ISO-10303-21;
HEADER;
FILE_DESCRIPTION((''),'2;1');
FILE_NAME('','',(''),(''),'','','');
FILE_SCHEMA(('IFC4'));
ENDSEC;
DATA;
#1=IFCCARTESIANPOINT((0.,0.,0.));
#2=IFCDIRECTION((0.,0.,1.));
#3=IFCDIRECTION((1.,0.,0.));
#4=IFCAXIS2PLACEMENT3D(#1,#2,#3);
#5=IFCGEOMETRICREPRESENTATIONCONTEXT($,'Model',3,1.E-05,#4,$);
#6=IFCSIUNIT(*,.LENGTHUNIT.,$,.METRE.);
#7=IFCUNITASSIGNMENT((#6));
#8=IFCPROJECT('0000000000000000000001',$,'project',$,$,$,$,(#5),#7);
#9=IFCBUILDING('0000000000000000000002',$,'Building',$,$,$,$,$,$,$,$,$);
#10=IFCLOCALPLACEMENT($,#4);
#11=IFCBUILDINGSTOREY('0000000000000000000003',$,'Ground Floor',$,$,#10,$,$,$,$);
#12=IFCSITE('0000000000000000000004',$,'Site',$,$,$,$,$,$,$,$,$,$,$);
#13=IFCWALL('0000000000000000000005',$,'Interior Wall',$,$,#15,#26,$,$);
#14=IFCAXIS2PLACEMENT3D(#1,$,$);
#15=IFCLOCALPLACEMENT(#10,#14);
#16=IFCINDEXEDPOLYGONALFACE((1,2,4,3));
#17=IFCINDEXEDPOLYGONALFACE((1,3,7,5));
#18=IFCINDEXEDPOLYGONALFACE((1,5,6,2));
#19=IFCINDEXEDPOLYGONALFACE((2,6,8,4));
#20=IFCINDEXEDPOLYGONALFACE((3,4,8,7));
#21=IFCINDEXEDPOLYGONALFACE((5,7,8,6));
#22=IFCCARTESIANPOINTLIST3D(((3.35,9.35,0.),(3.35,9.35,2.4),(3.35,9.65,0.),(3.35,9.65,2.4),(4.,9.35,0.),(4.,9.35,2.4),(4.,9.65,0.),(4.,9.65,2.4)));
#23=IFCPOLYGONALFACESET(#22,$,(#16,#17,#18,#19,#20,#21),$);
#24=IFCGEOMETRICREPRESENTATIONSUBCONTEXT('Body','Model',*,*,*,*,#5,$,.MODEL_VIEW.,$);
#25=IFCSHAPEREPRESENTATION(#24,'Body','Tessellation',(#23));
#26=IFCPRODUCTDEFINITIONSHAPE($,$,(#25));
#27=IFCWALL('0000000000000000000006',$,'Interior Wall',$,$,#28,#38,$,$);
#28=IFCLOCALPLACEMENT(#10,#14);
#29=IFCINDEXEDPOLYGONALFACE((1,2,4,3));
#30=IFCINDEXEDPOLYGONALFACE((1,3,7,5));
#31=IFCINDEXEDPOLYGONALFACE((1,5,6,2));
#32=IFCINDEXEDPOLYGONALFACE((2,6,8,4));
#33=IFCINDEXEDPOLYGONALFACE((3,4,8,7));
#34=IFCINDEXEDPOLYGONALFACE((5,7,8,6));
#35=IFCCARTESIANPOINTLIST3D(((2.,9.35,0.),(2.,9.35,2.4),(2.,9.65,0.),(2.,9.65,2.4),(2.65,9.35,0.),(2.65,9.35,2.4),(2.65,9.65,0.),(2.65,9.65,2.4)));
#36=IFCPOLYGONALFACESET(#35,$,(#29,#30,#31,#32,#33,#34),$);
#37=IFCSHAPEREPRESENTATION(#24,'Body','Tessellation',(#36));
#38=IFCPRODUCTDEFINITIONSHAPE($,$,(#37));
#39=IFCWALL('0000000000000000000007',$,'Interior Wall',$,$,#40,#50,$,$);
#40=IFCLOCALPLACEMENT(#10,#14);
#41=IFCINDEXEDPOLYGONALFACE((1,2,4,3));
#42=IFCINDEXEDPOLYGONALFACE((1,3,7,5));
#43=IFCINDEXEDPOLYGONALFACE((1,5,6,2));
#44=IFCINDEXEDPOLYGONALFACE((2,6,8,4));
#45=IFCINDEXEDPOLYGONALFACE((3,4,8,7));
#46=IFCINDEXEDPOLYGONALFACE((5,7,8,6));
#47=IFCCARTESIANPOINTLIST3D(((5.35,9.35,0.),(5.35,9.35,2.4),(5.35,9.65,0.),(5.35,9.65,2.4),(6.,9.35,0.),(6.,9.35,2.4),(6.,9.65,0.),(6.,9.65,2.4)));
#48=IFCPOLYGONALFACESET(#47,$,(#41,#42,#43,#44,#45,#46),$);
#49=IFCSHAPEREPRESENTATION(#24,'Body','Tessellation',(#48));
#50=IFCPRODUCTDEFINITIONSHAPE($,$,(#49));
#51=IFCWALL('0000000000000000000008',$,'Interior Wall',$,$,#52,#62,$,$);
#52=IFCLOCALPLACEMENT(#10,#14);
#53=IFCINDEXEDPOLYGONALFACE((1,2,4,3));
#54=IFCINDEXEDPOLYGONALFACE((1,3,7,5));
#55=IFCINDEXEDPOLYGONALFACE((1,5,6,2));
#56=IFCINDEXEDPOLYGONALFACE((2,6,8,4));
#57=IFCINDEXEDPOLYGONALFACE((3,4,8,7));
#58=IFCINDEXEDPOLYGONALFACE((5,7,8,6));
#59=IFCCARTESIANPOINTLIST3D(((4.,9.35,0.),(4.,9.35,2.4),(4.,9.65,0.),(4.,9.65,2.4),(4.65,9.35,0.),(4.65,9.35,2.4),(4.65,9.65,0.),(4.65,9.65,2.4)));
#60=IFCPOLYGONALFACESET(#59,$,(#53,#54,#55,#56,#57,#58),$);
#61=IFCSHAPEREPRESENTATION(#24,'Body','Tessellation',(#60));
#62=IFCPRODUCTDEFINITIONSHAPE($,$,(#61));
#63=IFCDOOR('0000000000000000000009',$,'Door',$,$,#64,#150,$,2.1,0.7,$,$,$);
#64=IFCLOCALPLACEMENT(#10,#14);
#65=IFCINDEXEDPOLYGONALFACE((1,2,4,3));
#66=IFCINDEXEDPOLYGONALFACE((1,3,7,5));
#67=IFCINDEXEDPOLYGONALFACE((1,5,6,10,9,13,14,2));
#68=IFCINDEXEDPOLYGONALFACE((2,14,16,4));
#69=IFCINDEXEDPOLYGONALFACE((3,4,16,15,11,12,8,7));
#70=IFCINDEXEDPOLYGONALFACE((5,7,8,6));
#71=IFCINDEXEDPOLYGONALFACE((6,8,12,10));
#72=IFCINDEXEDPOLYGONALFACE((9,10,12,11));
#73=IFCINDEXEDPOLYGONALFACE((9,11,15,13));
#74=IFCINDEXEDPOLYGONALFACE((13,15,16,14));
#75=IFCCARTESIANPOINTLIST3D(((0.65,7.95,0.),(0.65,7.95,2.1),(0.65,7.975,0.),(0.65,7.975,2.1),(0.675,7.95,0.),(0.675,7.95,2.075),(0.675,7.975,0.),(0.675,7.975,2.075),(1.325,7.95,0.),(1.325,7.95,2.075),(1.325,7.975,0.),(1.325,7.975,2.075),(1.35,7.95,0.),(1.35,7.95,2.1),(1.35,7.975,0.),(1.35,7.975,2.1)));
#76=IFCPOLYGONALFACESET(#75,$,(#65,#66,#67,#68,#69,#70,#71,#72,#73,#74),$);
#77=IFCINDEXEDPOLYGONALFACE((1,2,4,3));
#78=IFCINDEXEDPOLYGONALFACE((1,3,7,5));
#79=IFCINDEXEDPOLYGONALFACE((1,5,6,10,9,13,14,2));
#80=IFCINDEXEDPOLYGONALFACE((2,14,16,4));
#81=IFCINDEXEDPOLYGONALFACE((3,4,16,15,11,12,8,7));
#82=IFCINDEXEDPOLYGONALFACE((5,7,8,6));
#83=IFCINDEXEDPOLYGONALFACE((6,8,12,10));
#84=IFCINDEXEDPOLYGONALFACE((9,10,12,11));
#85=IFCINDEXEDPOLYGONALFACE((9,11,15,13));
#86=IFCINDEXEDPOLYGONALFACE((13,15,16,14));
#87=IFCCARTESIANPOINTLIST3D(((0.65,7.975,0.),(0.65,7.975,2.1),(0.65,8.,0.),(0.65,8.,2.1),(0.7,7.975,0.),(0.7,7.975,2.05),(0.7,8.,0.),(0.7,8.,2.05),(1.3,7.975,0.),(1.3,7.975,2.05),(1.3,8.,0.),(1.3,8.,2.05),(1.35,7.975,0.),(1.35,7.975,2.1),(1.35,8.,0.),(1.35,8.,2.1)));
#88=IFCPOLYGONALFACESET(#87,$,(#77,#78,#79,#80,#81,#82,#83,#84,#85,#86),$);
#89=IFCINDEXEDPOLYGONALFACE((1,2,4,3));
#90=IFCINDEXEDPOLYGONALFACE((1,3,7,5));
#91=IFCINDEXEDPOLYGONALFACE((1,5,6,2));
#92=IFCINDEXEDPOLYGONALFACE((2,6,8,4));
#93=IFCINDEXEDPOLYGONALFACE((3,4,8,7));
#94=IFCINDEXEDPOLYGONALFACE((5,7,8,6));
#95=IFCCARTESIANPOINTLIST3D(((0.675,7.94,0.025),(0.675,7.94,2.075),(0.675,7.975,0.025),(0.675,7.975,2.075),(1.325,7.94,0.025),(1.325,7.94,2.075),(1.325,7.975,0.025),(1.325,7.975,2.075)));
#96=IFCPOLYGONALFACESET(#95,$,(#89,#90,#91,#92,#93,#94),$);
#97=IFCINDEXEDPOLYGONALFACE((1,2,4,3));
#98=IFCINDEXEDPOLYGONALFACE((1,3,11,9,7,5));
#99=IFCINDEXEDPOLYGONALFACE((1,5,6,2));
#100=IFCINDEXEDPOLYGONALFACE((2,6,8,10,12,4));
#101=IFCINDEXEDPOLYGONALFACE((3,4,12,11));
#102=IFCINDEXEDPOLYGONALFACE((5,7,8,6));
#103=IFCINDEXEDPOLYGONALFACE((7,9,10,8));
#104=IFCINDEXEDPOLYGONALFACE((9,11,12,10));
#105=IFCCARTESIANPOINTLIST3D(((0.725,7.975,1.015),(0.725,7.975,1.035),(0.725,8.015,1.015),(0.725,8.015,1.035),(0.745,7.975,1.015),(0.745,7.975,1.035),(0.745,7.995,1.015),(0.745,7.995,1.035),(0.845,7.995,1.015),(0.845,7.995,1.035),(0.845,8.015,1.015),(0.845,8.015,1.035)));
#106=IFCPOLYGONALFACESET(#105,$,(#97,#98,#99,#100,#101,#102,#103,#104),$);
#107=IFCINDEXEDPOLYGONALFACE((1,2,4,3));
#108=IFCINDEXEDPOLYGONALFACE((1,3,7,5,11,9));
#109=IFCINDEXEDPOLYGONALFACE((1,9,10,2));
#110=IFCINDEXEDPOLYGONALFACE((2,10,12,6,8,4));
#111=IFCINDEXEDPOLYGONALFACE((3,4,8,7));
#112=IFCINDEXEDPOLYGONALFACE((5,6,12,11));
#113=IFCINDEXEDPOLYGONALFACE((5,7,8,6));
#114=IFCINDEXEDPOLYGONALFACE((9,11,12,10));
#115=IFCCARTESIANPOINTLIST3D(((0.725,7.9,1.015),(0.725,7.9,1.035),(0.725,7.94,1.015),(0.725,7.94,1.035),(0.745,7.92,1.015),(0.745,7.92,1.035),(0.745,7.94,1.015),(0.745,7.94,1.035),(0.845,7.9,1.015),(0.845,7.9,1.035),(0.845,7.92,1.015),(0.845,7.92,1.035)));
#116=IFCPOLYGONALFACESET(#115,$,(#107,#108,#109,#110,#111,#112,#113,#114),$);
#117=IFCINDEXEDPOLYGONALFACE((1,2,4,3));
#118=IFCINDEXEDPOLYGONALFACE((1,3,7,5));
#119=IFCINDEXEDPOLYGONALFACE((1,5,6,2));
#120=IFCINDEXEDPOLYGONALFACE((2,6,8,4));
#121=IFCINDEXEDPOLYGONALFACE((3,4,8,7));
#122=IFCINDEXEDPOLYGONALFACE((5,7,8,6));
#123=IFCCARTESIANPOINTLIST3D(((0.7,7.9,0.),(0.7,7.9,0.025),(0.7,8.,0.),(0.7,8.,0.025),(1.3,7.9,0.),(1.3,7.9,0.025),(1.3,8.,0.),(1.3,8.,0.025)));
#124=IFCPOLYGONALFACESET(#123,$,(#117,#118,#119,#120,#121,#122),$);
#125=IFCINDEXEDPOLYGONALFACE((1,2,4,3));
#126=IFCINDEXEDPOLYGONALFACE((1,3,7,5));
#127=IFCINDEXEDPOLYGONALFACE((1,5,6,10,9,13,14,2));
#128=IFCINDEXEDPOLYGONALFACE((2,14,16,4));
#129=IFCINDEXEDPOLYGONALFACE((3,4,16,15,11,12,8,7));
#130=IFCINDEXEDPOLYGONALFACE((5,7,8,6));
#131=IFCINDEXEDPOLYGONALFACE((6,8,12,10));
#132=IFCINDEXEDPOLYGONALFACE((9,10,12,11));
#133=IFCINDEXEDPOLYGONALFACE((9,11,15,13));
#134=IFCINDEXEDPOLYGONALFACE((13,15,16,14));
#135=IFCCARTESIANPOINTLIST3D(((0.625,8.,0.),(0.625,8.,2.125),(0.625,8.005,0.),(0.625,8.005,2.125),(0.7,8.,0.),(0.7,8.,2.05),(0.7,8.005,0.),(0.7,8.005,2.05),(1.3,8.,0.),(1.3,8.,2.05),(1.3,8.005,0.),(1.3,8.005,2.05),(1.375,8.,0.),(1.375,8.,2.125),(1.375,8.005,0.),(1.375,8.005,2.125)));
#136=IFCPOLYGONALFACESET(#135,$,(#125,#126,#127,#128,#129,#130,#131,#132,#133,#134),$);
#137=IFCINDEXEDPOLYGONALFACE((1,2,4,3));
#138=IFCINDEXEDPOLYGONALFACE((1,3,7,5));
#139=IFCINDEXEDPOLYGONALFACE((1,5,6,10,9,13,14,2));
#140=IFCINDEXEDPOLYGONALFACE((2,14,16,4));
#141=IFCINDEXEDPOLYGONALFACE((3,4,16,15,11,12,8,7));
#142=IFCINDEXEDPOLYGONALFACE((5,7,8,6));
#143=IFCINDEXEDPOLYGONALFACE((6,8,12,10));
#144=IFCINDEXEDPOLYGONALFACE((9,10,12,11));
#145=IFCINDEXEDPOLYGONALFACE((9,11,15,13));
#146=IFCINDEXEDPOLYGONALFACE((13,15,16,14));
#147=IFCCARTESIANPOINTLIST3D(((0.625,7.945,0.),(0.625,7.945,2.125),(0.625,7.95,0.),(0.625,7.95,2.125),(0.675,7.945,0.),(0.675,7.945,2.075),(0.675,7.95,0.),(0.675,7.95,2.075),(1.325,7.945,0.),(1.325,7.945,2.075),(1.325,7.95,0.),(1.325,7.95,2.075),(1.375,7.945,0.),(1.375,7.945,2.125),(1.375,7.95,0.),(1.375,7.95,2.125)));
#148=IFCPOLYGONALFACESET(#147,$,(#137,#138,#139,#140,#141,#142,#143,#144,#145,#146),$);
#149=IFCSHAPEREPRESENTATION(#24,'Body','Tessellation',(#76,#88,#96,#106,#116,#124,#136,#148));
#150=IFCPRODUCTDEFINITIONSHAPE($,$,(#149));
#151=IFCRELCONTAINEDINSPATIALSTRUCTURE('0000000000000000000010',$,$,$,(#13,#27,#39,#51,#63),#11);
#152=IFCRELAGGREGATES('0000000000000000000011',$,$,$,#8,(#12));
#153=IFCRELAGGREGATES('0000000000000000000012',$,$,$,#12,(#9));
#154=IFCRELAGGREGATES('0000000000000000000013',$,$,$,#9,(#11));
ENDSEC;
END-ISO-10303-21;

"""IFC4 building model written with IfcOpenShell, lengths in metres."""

from ifc_helpers import new_model, si_unit, frame, origin_with_axes, place, context, subcontext, project, spatial, line, indexed_curve, outline, extrude, element, save


model = new_model("IFC4")

# Units and contexts
model_context = context("Model", 3, precision=1e-05, world=origin_with_axes())
body_context = subcontext(model_context, "Body", "Model", "MODEL_VIEW")
ifc_project = project(units=[si_unit("LENGTHUNIT", "METRE")], contexts=[model_context])

# Site, building, storey
site = spatial("IfcSite", under=ifc_project, Name="Site")
building = spatial("IfcBuilding", under=site, Name="Building")
storey_placement = place(None, origin_with_axes())
storey = spatial("IfcBuildingStorey", under=building, at=storey_placement, Name="Ground Floor")

# Walls
for number, where, z_axis, x_axis, name in (
    (1, (4.0, 9.5, 0.0), (0.0, 0.0, 1.0), (-1.0, 0.0, 0.0), "Interior Wall"),
    (2, (2.65, 9.5, 0.0), (0.0, 0.0, 1.0), (-1.0, 0.0, 0.0), "Interior Wall"),
):
    element("IfcWall", number, at=place(storey_placement, frame(where, z_axis=z_axis, x_axis=x_axis)), inside=storey, Name=name, context=body_context, shape_type="SweptSolid", body=[
        extrude(outline(indexed_curve([(0.0, 0.0), (0.0, 0.3), (0.65, 0.3), (0.65, 0.0), (0.0, 0.0)], self_intersect=False)), frame((0.0, -0.15, 0.0), z_axis=(0.0, 0.0, 1.0), x_axis=(1.0, 0.0, 0.0)), (0.0, 0.0, 1.0), 2.4),
    ])
for number, where, z_axis, x_axis, name in (
    (3, (6.0, 9.5, 0.0), (0.0, 0.0, 1.0), (-1.0, 0.0, 0.0), "Interior Wall"),
    (4, (4.65, 9.5, 0.0), (0.0, 0.0, 1.0), (-1.0, 0.0, 0.0), "Interior Wall"),
):
    element("IfcWall", number, at=place(storey_placement, frame(where, z_axis=z_axis, x_axis=x_axis)), inside=storey, Name=name, context=body_context, shape_type="SweptSolid", body=[
        extrude(outline(indexed_curve([(0.0, 0.0), (0.0, 0.3), (0.65, 0.3), (0.65, 0.0), (0.0, 0.0)], self_intersect=False)), frame((0.0, -0.15, 0.0), z_axis=(0.0, 0.0, 1.0), x_axis=(1.0, 0.0, 0.0)), (0.0, 0.0, 1.0), 2.4),
    ])

# Door
door_1_placement = place(storey_placement, frame((1.35, 8.0, 0.0), z_axis=(0.0, 0.0, 1.0), x_axis=(-1.0, 0.0, 0.0)))
element("IfcDoor", 5, at=door_1_placement, inside=storey, Name="Door", OverallHeight=2.1, OverallWidth=0.7, context=body_context, shape_type="SweptSolid", body=[
    extrude(outline(indexed_curve([(0.0, 0.0), (0.0, 2.1), (0.7, 2.1), (0.7, 0.0), (0.675, 0.0), (0.675, 2.075), (0.025, 2.075), (0.025, 0.0)], segments=[line(1, 2, 3, 4, 5, 6, 7, 8, 1)])), frame((0.0, 0.025, 0.0), z_axis=(0.0, -1.0, 0.0), x_axis=(1.0, 0.0, 0.0)), (0.0, 0.0, -1.0), 0.025),
    extrude(outline(indexed_curve([(0.0, 0.0), (0.0, 2.1), (0.7, 2.1), (0.7, 0.0), (0.65, 0.0), (0.65, 2.05), (0.05, 2.05), (0.05, 0.0)], segments=[line(1, 2, 3, 4, 5, 6, 7, 8, 1)])), frame((0.0, 0.0, 0.0), z_axis=(0.0, -1.0, 0.0), x_axis=(1.0, 0.0, 0.0)), (0.0, 0.0, -1.0), 0.025),
    extrude(outline(indexed_curve([(0.0, 0.0), (0.65, 0.0), (0.65, 0.035), (0.0, 0.035)], segments=[line(1, 2, 3, 4, 1)])), frame((0.025, 0.025, 0.025), z_axis=(0.0, 0.0, 1.0), x_axis=(1.0, 0.0, 0.0)), (0.0, 0.0, 1.0), 2.05),
    extrude(outline(indexed_curve([(0.0, 0.0), (0.0, -0.04), (-0.12, -0.04), (-0.12, -0.02), (-0.02, -0.02), (-0.02, 0.0)], segments=[line(1, 2, 3, 4, 5, 6, 1)])), frame((0.625, 0.025, 1.015), z_axis=(0.0, 0.0, 1.0), x_axis=(1.0, 0.0, 0.0)), (0.0, 0.0, 1.0), 0.02),
    extrude(outline(indexed_curve([(0.0, 0.0), (0.0, 0.04), (-0.12, 0.04), (-0.12, 0.02), (-0.02, 0.02), (-0.02, 0.0)], segments=[line(1, 2, 3, 4, 5, 6, 1)])), frame((0.625, 0.06, 1.015), z_axis=(0.0, 0.0, 1.0), x_axis=(1.0, 0.0, 0.0)), (0.0, 0.0, 1.0), 0.02),
    extrude(outline(indexed_curve([(0.0, 0.0), (0.6, 0.0), (0.6, 0.1), (0.0, 0.1)], segments=[line(1, 2, 3, 4, 1)])), frame((0.05, 0.0, 0.0), z_axis=(0.0, 0.0, 1.0), x_axis=(1.0, 0.0, 0.0)), (0.0, 0.0, 1.0), 0.025),
    extrude(outline(indexed_curve([(0.0, 0.0), (0.0, 2.125), (0.75, 2.125), (0.75, 0.0), (0.675, 0.0), (0.675, 2.05), (0.075, 2.05), (0.075, 0.0)], segments=[line(1, 2, 3, 4, 5, 6, 7, 8, 1)])), frame((-0.025, -0.005, 0.0), z_axis=(0.0, -1.0, 0.0), x_axis=(1.0, 0.0, 0.0)), (0.0, 0.0, -1.0), 0.005),
    extrude(outline(indexed_curve([(0.0, 0.0), (0.0, 2.125), (0.75, 2.125), (0.75, 0.0), (0.7, 0.0), (0.7, 2.075), (0.05, 2.075), (0.05, 0.0)], segments=[line(1, 2, 3, 4, 5, 6, 7, 8, 1)])), frame((-0.025, 0.05, 0.0), z_axis=(0.0, -1.0, 0.0), x_axis=(1.0, 0.0, 0.0)), (0.0, 0.0, -1.0), 0.005),
])

save(model, "model.ifc")
